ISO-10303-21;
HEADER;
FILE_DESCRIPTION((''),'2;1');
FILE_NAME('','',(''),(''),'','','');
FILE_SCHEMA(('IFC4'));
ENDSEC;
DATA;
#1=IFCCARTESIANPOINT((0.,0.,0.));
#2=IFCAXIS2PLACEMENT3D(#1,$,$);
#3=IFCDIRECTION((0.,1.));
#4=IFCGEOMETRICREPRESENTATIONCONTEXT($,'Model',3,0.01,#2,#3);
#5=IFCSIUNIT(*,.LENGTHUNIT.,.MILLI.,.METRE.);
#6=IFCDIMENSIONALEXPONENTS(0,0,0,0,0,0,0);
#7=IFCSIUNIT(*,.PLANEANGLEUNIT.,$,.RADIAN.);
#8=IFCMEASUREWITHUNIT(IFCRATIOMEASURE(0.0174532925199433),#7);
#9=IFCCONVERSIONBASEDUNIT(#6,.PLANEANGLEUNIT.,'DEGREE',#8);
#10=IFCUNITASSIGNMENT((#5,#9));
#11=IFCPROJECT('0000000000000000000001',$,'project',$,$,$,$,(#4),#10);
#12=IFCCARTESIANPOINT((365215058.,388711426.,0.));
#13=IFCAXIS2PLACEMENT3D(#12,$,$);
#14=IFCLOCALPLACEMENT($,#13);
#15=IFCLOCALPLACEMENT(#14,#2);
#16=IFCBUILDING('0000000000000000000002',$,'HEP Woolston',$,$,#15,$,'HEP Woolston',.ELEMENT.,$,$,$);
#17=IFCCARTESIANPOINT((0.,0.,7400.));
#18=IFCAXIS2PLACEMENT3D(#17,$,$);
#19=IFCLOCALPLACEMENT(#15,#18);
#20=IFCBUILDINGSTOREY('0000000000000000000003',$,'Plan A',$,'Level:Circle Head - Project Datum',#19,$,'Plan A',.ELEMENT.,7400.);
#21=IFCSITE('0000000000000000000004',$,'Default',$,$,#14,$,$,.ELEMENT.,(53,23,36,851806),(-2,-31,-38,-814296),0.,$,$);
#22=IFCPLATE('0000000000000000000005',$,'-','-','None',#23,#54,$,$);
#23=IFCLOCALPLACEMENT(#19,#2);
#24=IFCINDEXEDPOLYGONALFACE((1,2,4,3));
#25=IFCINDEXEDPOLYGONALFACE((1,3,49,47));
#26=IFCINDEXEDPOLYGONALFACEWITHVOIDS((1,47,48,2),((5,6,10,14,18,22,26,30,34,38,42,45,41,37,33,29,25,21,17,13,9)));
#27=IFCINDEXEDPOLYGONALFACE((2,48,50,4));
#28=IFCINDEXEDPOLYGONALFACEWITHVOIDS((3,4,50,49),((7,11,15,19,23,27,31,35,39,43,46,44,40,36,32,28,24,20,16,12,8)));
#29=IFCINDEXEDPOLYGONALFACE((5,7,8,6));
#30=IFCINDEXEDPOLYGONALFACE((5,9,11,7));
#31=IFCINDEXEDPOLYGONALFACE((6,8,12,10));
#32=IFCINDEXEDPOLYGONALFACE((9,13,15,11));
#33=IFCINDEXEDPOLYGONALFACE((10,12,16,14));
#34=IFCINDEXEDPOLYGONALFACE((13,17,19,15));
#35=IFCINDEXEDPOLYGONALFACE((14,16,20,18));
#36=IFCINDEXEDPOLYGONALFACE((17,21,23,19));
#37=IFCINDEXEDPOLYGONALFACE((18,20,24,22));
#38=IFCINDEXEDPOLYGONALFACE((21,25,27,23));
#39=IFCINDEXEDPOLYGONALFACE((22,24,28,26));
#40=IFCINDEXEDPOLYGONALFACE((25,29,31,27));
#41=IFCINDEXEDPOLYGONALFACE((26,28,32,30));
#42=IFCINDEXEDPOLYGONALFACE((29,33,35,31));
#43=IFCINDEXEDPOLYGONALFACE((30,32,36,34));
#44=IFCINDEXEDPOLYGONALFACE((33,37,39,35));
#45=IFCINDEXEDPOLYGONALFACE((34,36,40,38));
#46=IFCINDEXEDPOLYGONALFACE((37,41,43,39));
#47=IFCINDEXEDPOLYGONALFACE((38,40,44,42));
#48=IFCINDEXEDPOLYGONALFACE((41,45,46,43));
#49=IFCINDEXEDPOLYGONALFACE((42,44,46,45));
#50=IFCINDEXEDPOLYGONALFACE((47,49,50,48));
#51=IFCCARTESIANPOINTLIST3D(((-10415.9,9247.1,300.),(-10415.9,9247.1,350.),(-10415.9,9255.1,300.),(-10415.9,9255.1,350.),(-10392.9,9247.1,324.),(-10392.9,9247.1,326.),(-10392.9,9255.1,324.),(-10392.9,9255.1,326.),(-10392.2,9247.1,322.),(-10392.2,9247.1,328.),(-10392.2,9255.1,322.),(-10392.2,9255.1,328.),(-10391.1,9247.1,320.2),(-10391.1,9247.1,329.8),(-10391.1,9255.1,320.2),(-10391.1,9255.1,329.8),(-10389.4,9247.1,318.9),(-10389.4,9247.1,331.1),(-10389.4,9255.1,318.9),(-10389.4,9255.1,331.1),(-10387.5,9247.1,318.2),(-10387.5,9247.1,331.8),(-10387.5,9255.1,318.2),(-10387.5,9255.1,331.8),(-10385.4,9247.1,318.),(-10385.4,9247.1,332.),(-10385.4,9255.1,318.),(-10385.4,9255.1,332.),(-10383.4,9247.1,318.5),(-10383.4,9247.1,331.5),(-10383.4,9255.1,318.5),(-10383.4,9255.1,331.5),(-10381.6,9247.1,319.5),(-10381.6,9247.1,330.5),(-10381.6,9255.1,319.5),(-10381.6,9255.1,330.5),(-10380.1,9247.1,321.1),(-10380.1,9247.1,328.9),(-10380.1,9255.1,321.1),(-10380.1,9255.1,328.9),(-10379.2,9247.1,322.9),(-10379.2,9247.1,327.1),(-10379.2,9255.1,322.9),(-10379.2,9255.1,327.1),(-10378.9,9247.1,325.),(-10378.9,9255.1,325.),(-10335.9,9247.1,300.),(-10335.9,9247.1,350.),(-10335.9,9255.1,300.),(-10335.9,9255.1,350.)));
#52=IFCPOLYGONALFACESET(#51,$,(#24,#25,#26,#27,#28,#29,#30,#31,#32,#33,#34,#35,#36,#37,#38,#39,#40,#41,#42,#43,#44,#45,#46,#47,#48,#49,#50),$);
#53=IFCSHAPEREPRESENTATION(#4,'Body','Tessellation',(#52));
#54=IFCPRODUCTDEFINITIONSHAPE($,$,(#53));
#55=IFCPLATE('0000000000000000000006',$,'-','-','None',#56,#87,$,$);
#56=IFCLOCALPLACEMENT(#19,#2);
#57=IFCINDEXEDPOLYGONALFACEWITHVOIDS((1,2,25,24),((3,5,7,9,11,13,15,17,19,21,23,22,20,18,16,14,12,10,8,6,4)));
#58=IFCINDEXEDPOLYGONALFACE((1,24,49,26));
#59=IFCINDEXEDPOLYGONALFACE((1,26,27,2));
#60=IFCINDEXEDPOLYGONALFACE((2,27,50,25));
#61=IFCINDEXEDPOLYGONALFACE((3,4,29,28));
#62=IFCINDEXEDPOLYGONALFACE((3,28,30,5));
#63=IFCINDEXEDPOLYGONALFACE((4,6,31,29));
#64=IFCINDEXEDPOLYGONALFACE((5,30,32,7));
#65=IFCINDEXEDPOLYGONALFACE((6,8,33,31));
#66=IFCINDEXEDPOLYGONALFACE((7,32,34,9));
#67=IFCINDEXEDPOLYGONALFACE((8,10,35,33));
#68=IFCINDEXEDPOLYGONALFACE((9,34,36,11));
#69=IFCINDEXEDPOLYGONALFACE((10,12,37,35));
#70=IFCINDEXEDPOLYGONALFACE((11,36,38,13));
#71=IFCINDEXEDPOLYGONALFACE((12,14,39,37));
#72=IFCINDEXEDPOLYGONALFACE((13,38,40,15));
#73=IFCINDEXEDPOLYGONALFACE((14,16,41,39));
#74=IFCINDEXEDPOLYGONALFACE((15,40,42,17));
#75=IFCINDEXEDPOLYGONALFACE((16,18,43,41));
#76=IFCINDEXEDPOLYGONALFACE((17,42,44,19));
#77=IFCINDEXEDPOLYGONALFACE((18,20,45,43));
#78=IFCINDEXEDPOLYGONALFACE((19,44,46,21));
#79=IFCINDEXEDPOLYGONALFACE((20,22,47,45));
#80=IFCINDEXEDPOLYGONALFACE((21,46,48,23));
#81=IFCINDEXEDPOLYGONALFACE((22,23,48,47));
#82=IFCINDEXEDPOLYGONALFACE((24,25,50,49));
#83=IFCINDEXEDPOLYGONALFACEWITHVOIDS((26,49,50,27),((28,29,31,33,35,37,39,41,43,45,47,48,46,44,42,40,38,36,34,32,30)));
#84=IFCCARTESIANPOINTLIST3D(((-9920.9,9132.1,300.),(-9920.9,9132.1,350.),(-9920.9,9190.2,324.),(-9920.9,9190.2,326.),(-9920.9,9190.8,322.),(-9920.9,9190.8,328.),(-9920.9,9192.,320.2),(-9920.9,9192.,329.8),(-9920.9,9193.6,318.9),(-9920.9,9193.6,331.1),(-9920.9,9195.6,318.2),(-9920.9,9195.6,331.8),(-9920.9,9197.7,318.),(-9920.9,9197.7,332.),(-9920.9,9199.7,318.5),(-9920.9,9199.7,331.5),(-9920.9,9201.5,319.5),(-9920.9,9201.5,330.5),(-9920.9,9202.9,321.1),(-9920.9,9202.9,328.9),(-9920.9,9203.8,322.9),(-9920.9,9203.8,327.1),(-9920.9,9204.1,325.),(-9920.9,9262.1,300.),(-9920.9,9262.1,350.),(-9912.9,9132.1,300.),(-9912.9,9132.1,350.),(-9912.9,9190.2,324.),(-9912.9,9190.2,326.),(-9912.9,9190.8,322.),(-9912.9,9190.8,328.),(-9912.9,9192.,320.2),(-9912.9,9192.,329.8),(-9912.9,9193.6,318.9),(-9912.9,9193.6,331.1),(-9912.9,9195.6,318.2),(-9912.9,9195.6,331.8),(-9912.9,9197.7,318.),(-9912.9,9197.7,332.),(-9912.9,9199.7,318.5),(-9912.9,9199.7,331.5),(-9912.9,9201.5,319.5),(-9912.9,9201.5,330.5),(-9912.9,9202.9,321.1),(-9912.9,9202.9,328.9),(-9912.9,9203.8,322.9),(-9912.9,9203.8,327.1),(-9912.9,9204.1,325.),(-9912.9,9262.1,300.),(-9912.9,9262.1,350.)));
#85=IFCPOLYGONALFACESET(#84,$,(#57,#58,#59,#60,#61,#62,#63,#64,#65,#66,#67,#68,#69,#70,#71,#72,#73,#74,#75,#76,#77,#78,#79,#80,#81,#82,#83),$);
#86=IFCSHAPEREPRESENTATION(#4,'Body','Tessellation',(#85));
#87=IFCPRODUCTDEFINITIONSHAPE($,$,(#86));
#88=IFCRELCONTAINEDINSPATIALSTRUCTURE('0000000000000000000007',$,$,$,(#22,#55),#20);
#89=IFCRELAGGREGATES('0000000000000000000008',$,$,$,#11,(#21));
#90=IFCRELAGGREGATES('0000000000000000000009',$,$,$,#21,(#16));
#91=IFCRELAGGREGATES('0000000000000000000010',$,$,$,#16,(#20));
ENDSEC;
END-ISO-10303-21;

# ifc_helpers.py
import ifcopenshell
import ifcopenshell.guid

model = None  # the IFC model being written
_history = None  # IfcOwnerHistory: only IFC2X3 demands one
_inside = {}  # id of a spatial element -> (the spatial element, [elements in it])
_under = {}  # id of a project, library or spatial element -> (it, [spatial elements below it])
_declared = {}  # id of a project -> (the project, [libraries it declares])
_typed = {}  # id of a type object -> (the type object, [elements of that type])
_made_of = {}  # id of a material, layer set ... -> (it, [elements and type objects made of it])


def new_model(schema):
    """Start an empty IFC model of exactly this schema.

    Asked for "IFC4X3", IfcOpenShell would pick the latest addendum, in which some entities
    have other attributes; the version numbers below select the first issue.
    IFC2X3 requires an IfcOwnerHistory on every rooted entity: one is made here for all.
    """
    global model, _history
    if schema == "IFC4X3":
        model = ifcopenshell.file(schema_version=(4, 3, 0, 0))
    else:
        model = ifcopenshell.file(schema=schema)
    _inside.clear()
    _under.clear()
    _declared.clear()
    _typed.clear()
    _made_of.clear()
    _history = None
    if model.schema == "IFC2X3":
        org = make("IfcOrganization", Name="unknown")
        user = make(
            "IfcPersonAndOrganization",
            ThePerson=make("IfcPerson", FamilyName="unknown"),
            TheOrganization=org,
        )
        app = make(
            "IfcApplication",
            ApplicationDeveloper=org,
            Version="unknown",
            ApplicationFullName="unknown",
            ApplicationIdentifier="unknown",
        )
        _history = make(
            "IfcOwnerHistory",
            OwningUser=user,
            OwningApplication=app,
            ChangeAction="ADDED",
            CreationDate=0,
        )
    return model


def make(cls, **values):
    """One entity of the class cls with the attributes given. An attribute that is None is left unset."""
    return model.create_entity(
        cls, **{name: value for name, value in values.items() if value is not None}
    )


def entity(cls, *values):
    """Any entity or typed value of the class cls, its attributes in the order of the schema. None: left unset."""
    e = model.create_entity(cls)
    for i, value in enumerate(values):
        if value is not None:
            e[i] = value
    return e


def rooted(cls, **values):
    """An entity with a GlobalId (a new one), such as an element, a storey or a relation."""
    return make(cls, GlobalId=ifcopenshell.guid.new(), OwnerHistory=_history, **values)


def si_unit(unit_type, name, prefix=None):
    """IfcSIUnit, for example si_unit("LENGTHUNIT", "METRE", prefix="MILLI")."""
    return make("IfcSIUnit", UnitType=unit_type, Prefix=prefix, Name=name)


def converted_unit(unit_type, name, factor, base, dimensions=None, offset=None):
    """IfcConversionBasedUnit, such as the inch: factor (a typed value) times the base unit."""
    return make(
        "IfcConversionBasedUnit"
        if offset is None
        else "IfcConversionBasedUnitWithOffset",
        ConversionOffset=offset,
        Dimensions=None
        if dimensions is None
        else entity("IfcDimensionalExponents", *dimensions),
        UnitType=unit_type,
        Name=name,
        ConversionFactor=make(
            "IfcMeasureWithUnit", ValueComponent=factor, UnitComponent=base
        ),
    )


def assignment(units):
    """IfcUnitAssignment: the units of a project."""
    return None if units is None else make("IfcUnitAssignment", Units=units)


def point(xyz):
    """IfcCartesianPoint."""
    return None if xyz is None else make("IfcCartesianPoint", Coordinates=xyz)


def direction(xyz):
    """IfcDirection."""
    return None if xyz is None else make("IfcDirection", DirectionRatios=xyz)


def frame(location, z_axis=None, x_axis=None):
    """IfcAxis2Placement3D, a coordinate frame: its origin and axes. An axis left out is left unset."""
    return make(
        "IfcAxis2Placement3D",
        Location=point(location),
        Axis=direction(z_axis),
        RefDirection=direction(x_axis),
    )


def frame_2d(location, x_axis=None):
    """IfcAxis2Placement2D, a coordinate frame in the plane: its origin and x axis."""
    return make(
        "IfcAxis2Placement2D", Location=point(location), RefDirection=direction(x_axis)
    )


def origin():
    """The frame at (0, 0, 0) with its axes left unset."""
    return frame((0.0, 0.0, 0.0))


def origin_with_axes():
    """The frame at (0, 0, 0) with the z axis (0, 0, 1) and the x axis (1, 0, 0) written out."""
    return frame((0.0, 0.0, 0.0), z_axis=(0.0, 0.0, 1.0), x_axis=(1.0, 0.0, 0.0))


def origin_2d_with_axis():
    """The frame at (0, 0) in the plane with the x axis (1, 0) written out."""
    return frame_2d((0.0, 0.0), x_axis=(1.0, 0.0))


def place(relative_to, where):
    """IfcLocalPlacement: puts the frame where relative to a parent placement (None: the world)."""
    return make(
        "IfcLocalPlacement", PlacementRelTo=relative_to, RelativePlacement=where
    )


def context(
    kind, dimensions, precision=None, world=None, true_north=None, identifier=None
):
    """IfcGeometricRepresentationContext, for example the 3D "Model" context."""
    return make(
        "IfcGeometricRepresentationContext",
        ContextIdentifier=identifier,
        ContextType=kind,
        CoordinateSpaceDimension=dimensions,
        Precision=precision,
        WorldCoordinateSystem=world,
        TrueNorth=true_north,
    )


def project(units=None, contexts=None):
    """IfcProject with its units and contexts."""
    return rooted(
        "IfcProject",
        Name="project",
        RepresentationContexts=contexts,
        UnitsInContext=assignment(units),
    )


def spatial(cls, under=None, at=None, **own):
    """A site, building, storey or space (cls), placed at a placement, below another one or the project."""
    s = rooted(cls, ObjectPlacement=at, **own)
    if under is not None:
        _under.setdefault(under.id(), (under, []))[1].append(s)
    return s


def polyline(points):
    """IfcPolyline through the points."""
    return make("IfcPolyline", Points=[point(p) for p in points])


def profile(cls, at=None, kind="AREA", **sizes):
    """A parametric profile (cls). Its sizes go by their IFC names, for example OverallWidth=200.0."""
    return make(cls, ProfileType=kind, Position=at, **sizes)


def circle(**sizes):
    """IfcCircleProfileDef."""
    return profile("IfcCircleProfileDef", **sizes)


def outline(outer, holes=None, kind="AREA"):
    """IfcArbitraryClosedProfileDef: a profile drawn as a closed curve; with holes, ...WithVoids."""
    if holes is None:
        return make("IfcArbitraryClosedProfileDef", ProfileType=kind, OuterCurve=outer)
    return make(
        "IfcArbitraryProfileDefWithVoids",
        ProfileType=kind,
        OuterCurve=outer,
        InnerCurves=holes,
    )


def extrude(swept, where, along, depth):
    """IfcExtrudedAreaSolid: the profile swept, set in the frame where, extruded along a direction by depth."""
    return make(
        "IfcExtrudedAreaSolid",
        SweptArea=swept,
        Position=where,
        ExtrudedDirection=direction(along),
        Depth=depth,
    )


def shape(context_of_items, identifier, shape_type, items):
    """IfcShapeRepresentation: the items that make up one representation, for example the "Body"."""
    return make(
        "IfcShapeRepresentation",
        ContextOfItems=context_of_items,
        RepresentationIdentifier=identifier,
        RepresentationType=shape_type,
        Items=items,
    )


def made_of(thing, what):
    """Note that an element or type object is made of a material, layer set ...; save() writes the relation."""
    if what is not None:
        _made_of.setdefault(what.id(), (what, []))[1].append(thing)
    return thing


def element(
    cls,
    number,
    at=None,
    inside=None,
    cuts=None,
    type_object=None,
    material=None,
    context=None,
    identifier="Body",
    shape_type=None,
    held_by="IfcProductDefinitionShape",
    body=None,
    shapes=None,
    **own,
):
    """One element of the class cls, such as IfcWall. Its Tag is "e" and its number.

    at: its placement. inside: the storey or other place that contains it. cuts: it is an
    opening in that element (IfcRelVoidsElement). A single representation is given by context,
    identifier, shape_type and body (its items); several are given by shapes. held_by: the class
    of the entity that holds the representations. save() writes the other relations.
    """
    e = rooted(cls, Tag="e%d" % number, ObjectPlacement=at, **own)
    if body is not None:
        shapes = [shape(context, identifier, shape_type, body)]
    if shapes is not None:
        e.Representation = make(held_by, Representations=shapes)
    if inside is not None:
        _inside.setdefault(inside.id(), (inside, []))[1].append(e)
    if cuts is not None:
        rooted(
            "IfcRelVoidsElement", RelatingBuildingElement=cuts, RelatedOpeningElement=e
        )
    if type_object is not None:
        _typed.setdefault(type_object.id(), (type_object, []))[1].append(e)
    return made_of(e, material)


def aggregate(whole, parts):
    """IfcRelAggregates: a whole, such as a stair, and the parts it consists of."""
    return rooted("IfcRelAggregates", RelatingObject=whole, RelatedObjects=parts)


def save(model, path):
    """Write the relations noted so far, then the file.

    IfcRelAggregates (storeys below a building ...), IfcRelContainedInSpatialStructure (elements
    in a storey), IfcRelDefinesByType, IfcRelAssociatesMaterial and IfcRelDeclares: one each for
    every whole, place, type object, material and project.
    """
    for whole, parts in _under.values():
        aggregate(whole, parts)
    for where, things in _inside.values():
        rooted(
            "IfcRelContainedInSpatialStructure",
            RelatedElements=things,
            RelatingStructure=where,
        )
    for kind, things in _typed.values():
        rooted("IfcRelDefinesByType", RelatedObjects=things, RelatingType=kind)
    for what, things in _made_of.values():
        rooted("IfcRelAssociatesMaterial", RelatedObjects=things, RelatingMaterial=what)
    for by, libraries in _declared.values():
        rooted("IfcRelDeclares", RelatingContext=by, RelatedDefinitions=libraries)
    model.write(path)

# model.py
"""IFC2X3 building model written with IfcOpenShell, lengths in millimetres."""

from ifc_helpers import new_model, entity, si_unit, converted_unit, direction, frame, origin, origin_with_axes, origin_2d_with_axis, place, context, project, spatial, polyline, circle, outline, extrude, element, save


model = new_model("IFC2X3")

# Units and contexts
model_context = context("Model", 3, precision=0.01, world=origin(), true_north=direction((0.0, 1.0)))
ifc_project = project(units=[si_unit("LENGTHUNIT", "METRE", prefix="MILLI"), converted_unit("PLANEANGLEUNIT", "DEGREE", entity("IfcRatioMeasure", 0.0174532925199433), si_unit("PLANEANGLEUNIT", "RADIAN"), dimensions=[0, 0, 0, 0, 0, 0, 0])], contexts=[model_context])

# Site, building, storey
site_placement = place(None, frame((365215058.0, 388711426.0, 0.0)))
site = spatial("IfcSite", under=ifc_project, at=site_placement, Name="Default", CompositionType="ELEMENT", RefLatitude=(53, 23, 36, 851806), RefLongitude=(-2, -31, -38, -814296), RefElevation=0.0)
building_placement = place(site_placement, origin())
building = spatial("IfcBuilding", under=site, at=building_placement, Name="HEP Woolston", LongName="HEP Woolston", CompositionType="ELEMENT")
storey_placement = place(building_placement, frame((0.0, 0.0, 7400.0)))
storey = spatial("IfcBuildingStorey", under=building, at=storey_placement, Name="Plan A", ObjectType="Level:Circle Head - Project Datum", LongName="Plan A", CompositionType="ELEMENT", Elevation=7400.0)

# Plates, openings
plate_1_placement = place(storey_placement, frame((-10335.9, 9247.1, 350.0), z_axis=(0.0, 1.0, 0.0), x_axis=(-1.0, 0.0, 0.0)))
plate_1 = element("IfcPlate", 1, at=plate_1_placement, inside=storey, Name="-", Description="-", ObjectType="None", context=model_context, shape_type="SweptSolid", body=[
    extrude(outline(polyline([(0.0, 0.0), (0.0, -50.0), (80.0, -50.0), (80.0, 0.0), (0.0, 0.0)])), origin_with_axes(), (0.0, 0.0, 1.0), 8.0),
])
opening_1_placement = place(plate_1_placement, frame((50.0, -25.0, 8.5), z_axis=(0.0, 0.0, -1.0), x_axis=(-1.0, 0.0, 0.0)))
element("IfcOpeningElement", 2, at=opening_1_placement, cuts=plate_1, ObjectType="Opening", context=model_context, shape_type="SweptSolid", body=[
    extrude(circle(Radius=7.0, at=origin_2d_with_axis()), origin(), (0.0, 0.0, 1.0), 9.0),
])
plate_2_placement = place(storey_placement, frame((-9920.9, 9132.1, 350.0), z_axis=(1.0, 0.0, 0.0), x_axis=(0.0, 1.0, 0.0)))
plate_2 = element("IfcPlate", 3, at=plate_2_placement, inside=storey, Name="-", Description="-", ObjectType="None", context=model_context, shape_type="SweptSolid", body=[
    extrude(outline(polyline([(0.0, -50.0), (130.0, -50.0), (130.0, 0.0), (0.0, 0.0), (0.0, -50.0)])), origin_with_axes(), (0.0, 0.0, 1.0), 8.0),
])
opening_2_placement = place(plate_2_placement, frame((65.0, -25.0, 8.5), z_axis=(0.0, 0.0, -1.0), x_axis=(1.0, 0.0, 0.0)))
element("IfcOpeningElement", 4, at=opening_2_placement, cuts=plate_2, ObjectType="Opening", context=model_context, shape_type="SweptSolid", body=[
    extrude(circle(Radius=7.0, at=origin_2d_with_axis()), origin(), (0.0, 0.0, 1.0), 9.0),
])

save(model, "model.ifc")
